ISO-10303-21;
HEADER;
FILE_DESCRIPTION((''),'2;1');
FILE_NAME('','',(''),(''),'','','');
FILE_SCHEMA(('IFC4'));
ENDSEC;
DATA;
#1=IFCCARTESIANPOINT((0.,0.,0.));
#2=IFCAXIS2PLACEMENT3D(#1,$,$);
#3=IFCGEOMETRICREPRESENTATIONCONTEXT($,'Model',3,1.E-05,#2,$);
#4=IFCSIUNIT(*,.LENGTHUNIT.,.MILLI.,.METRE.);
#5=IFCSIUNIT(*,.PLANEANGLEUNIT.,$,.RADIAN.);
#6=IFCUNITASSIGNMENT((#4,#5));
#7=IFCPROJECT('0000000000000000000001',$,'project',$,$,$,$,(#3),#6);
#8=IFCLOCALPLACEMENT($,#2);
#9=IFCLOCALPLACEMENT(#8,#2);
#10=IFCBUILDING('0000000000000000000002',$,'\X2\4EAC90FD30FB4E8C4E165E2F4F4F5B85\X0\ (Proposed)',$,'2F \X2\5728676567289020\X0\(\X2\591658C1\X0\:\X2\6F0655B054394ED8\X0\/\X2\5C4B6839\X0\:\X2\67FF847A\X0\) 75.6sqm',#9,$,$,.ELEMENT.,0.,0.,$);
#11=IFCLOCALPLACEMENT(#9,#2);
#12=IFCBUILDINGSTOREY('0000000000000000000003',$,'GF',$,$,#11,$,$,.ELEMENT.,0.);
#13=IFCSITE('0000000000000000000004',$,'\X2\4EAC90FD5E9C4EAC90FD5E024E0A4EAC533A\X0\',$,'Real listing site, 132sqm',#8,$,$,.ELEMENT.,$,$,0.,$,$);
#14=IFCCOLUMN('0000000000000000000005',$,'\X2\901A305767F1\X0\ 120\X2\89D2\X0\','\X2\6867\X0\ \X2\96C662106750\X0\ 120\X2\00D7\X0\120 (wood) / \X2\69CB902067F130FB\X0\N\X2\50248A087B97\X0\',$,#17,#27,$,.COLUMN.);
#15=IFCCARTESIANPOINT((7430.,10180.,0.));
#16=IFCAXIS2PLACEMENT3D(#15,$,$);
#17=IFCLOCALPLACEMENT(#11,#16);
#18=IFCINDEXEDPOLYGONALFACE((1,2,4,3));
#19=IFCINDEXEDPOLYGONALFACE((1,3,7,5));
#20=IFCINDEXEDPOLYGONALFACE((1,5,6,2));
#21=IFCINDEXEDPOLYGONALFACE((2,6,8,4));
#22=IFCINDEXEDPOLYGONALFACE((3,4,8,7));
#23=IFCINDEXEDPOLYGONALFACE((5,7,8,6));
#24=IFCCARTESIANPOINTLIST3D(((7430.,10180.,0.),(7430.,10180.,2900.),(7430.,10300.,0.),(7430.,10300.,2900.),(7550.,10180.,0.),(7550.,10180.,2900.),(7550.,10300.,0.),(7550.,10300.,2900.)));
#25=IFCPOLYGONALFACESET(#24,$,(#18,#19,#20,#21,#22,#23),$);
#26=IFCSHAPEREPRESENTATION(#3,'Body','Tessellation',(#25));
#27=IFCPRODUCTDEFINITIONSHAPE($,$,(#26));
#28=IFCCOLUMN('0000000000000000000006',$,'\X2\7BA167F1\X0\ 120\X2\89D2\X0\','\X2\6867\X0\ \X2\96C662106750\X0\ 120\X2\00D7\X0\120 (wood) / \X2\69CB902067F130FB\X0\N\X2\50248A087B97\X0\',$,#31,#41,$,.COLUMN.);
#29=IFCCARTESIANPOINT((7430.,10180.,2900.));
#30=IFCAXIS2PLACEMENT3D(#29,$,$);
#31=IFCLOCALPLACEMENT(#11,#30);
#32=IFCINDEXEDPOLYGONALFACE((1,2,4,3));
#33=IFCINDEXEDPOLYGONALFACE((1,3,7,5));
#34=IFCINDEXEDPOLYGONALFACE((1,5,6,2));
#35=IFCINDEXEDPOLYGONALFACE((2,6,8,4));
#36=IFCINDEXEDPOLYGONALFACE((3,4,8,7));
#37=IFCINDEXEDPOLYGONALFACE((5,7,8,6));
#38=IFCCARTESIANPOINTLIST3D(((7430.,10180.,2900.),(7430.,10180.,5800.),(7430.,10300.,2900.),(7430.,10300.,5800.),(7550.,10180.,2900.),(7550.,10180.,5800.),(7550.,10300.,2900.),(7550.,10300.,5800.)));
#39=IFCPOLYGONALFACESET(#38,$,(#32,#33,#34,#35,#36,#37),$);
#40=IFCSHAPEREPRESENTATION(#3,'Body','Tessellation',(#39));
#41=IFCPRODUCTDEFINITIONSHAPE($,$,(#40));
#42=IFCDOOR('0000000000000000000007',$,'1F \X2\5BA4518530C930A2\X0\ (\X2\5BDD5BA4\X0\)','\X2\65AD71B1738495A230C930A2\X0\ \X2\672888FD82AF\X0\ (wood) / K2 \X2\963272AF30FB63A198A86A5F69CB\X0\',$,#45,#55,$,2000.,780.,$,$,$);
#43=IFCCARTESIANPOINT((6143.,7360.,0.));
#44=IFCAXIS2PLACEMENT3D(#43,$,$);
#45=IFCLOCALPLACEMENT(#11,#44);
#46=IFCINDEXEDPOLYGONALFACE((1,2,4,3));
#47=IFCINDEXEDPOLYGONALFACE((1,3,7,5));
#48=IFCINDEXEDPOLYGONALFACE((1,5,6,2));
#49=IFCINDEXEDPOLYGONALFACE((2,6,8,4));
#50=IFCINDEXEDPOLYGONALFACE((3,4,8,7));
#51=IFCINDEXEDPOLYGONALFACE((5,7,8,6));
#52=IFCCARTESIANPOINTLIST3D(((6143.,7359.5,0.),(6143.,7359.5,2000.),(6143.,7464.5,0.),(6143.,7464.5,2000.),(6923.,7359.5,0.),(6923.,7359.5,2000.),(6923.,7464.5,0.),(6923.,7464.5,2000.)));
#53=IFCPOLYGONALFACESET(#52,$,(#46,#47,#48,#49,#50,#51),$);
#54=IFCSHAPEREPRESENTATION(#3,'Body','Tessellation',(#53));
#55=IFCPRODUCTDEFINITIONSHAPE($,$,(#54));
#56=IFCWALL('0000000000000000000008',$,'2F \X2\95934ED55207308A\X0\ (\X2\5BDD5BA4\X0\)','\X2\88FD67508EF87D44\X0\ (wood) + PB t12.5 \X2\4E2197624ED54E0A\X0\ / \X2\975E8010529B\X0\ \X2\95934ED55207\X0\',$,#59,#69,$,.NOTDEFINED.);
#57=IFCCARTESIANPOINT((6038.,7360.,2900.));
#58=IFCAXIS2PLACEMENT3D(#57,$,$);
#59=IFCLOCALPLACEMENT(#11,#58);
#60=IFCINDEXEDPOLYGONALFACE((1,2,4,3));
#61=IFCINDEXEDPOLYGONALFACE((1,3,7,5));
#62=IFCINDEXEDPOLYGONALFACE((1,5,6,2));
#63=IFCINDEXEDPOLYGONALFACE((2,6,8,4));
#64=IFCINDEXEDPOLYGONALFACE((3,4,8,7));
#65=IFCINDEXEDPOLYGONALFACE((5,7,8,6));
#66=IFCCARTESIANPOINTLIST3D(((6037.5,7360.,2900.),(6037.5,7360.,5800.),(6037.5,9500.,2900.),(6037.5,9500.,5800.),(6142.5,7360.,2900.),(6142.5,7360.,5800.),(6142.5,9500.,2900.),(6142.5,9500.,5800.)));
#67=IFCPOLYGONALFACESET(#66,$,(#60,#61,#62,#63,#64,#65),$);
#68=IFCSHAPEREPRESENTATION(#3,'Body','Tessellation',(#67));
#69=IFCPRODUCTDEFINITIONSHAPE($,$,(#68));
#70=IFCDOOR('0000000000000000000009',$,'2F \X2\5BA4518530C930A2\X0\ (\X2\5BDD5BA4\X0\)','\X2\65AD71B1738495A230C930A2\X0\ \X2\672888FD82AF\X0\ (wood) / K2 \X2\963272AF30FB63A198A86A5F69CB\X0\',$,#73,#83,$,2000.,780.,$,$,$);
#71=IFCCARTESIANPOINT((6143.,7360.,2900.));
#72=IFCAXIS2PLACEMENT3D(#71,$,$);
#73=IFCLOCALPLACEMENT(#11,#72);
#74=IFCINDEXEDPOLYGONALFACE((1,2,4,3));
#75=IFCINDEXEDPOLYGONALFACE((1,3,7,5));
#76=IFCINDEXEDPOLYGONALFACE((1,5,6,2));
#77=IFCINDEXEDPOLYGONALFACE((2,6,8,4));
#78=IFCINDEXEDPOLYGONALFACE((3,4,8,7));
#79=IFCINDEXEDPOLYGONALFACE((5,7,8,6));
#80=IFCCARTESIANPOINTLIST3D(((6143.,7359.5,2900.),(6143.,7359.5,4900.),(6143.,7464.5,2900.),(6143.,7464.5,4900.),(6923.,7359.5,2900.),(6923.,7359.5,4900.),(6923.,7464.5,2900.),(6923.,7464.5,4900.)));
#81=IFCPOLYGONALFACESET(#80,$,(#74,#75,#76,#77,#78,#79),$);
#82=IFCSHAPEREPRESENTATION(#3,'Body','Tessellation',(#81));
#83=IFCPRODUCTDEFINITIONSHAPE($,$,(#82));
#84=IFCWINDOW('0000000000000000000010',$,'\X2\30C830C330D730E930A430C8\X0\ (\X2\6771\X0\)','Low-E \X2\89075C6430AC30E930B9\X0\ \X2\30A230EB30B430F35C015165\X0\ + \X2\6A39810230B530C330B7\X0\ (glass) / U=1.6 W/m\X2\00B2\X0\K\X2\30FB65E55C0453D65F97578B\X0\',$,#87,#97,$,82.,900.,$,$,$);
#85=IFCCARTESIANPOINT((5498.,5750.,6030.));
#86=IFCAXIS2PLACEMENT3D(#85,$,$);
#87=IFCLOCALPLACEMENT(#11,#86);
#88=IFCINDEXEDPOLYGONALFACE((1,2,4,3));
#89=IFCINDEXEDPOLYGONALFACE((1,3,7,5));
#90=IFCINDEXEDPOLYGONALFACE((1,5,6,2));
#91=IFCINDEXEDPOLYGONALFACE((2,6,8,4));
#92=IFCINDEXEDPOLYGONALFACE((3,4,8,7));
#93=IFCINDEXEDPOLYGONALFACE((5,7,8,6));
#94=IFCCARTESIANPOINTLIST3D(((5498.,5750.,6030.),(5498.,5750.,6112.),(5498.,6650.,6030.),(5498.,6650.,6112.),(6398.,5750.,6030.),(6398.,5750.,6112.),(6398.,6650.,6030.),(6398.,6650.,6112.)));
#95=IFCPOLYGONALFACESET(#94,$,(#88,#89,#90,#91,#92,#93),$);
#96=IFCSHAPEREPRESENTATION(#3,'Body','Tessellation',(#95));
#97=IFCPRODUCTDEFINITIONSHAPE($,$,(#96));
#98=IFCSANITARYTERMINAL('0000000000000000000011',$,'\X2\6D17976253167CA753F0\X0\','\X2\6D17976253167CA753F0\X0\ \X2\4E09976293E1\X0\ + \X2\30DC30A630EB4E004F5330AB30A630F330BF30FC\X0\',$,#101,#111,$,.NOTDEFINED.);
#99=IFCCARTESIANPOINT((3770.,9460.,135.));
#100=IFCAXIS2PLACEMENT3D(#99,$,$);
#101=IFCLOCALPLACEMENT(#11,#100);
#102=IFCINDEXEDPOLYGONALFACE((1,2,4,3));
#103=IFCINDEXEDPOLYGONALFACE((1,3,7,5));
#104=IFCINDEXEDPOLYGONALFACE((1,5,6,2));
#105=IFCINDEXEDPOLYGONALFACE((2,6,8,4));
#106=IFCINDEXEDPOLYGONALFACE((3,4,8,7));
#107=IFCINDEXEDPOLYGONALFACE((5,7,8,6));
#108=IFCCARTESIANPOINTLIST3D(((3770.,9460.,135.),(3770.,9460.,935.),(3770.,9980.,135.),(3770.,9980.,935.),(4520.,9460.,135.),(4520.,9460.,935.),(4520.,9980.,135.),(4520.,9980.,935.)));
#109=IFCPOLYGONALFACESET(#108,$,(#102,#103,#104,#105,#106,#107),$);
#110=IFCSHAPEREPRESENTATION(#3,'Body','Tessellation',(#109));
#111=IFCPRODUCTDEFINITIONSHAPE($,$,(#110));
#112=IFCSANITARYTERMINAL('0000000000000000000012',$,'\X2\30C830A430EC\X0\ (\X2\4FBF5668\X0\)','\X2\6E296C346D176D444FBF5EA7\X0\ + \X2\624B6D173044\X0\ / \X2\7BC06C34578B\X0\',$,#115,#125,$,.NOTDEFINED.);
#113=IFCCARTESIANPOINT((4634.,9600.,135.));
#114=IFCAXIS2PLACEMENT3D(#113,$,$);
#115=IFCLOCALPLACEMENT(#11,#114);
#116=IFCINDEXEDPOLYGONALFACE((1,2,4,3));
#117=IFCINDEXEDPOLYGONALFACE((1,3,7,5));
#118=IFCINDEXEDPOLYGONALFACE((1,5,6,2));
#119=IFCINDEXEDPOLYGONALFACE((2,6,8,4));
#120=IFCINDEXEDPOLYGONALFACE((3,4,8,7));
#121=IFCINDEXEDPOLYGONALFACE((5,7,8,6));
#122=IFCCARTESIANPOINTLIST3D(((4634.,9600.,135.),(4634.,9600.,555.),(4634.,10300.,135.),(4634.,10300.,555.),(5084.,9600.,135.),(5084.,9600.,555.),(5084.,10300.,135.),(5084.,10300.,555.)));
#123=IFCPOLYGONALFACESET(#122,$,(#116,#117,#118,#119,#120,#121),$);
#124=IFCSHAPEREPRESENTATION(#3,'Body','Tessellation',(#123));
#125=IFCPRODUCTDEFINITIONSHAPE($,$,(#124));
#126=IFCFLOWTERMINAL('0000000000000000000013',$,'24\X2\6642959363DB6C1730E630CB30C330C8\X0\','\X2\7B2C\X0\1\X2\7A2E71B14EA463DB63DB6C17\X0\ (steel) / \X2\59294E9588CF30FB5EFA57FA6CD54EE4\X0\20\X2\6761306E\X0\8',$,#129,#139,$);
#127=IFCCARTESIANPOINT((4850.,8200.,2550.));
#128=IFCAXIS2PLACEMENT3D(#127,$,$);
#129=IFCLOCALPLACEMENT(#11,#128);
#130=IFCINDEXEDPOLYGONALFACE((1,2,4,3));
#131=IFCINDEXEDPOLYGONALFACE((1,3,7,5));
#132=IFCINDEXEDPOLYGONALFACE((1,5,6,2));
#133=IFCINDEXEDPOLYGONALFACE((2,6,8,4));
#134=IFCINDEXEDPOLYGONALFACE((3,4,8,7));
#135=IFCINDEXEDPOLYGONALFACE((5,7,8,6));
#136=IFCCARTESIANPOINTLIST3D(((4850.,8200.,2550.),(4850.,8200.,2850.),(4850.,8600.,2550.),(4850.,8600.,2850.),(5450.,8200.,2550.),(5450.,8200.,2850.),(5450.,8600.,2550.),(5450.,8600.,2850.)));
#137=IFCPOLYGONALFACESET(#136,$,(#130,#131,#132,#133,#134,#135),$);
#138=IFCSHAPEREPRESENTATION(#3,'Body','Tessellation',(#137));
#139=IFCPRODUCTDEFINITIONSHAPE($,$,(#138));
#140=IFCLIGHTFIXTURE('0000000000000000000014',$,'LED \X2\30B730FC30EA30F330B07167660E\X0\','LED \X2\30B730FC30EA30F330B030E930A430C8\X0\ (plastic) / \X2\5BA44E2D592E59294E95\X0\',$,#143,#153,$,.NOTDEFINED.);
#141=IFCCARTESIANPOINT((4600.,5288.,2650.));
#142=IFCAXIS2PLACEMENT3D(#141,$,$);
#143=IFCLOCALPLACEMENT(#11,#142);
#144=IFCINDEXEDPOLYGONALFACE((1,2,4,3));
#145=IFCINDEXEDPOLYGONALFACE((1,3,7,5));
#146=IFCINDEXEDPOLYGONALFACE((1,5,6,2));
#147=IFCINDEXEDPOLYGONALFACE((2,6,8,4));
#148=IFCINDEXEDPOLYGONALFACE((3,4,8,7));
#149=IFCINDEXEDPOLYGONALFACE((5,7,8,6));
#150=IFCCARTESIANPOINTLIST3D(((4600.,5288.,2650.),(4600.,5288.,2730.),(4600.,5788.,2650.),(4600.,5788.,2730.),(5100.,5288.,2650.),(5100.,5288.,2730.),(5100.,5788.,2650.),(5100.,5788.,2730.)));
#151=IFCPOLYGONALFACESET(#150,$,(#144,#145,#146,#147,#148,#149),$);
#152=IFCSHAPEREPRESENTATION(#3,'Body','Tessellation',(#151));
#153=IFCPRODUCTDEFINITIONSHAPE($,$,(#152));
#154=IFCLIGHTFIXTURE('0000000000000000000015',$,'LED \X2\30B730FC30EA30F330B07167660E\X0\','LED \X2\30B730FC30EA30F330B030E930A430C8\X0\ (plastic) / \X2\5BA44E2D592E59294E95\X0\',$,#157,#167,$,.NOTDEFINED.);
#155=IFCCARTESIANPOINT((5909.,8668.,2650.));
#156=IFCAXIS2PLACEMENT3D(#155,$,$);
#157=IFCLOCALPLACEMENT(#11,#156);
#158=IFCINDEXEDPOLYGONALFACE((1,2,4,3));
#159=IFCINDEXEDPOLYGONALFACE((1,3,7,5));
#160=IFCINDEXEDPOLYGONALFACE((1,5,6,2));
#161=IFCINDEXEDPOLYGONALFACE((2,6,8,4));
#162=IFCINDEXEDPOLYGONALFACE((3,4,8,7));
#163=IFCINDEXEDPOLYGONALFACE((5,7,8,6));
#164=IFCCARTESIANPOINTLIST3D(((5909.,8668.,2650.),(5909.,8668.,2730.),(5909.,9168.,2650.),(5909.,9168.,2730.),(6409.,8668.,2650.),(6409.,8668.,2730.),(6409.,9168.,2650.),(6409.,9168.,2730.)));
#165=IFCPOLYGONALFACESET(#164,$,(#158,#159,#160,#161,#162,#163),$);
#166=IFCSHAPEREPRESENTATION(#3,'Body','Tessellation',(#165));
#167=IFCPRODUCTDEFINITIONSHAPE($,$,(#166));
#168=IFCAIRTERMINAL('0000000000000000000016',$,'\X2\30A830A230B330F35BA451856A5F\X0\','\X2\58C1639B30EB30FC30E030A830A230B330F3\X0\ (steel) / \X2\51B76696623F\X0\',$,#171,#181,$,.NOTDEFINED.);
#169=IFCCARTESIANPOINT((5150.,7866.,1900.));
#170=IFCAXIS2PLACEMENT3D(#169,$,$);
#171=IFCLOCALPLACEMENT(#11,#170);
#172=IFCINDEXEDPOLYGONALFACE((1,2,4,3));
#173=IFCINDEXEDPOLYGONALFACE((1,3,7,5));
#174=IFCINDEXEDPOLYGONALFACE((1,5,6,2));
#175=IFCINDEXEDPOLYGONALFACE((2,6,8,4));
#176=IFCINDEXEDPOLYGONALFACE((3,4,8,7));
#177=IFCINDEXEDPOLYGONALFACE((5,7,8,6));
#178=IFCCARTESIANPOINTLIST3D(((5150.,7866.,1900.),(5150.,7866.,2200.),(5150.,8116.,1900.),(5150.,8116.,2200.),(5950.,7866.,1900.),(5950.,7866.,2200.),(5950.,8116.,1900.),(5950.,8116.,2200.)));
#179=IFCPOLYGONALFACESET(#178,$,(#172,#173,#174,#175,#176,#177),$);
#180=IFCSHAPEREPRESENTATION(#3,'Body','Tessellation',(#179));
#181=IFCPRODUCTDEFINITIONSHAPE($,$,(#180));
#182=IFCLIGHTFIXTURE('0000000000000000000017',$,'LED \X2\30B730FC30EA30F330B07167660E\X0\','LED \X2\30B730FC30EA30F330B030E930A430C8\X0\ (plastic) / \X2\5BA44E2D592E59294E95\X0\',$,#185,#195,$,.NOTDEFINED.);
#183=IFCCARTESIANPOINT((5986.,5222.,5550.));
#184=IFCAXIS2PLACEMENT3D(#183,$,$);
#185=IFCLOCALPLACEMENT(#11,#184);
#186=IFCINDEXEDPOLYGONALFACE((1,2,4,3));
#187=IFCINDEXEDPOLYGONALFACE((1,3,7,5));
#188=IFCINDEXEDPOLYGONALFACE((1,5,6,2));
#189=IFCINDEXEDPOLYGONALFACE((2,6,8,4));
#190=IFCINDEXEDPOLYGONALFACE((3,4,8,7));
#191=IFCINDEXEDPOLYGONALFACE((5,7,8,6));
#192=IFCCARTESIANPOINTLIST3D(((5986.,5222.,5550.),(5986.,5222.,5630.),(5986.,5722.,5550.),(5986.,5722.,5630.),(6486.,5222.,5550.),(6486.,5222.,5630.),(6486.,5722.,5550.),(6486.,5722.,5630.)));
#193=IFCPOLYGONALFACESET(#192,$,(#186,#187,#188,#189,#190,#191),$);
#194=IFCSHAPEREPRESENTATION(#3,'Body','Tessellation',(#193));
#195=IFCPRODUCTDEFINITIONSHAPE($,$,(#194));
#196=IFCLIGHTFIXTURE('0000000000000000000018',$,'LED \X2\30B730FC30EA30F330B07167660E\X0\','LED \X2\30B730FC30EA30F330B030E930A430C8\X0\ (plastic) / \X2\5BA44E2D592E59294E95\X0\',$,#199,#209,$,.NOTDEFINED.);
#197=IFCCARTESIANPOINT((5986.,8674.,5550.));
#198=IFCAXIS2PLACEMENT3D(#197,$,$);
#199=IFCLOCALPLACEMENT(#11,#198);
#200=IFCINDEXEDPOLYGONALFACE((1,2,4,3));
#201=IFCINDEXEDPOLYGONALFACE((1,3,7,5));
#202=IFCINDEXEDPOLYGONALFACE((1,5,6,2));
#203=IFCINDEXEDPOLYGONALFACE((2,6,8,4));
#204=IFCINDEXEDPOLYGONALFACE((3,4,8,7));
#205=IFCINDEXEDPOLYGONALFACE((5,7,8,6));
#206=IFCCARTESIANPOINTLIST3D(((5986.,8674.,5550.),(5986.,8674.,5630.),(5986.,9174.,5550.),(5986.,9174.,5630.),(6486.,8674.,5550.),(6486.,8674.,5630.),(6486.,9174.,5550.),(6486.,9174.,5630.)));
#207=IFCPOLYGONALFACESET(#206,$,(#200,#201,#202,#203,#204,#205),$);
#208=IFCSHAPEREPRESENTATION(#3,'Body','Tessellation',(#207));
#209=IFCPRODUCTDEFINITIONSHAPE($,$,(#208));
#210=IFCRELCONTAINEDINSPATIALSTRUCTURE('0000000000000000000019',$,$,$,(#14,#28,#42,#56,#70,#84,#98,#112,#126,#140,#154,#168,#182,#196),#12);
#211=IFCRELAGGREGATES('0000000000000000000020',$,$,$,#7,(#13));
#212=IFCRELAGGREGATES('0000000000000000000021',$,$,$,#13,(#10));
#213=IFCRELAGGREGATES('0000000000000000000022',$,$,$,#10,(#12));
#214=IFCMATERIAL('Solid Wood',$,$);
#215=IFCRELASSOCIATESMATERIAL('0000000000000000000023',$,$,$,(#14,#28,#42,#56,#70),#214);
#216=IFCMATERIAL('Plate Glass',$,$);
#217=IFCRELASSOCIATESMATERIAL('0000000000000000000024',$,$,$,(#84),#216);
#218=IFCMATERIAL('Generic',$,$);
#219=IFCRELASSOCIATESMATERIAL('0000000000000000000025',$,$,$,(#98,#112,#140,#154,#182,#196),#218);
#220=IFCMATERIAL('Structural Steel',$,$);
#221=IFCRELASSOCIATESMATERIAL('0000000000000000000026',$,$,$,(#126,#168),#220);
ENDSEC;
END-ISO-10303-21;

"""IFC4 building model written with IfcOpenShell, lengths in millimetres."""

from ifc_helpers import new_model, si_unit, frame, frame_2d, origin, place, context, project, spatial, rectangle, extrude, material, element, save


model = new_model("IFC4")

# Units and contexts
model_context = context("Model", 3, precision=1e-05, world=origin())
ifc_project = project(units=[si_unit("LENGTHUNIT", "METRE", prefix="MILLI"), si_unit("PLANEANGLEUNIT", "RADIAN")], contexts=[model_context])

# Site, building, storey
site_placement = place(None, origin())
site = spatial("IfcSite", under=ifc_project, at=site_placement, Name="京都府京都市上京区", ObjectType="Real listing site, 132sqm", CompositionType="ELEMENT", RefElevation=0.0)
building_placement = place(site_placement, origin())
building = spatial("IfcBuilding", under=site, at=building_placement, Name="京都・二世帯住宅 (Proposed)", ObjectType="2F 在来木造(外壁:漆喰吹付/屋根:柿葺) 75.6sqm", CompositionType="ELEMENT", ElevationOfRefHeight=0.0, ElevationOfTerrain=0.0)
storey_placement = place(building_placement, origin())
storey = spatial("IfcBuildingStorey", under=building, at=storey_placement, Name="GF", CompositionType="ELEMENT", Elevation=0.0)

# Columns
ifc_material_1 = material(Name="Solid Wood")
column_1_placement = place(storey_placement, frame((7430.0, 10180.0, 0.0)))
element("IfcColumn", 1, at=column_1_placement, inside=storey, material=ifc_material_1, Name="通し柱 120角", Description="桧 集成材 120×120 (wood) / 構造柱・N値計算", PredefinedType="COLUMN", context=model_context, shape_type="SweptSolid", body=[
    extrude(rectangle(XDim=120.0, YDim=120.0, at=frame_2d((60.0, 60.0))), frame((7430.0, 10180.0, 0.0)), (0.0, 0.0, 1.0), 2900.0),
])
column_2_placement = place(storey_placement, frame((7430.0, 10180.0, 2900.0)))
element("IfcColumn", 2, at=column_2_placement, inside=storey, material=ifc_material_1, Name="管柱 120角", Description="桧 集成材 120×120 (wood) / 構造柱・N値計算", PredefinedType="COLUMN", context=model_context, shape_type="SweptSolid", body=[
    extrude(rectangle(XDim=120.0, YDim=120.0, at=frame_2d((60.0, 60.0))), frame((7430.0, 10180.0, 2900.0)), (0.0, 0.0, 1.0), 2900.0),
])

# Door
door_1_placement = place(storey_placement, frame((6143.0, 7360.0, 0.0)))
element("IfcDoor", 3, at=door_1_placement, inside=storey, material=ifc_material_1, Name="1F 室内ドア (寝室)", Description="断熱玄関ドア 木製芯 (wood) / K2 防犯・採風機構", OverallHeight=2000.0, OverallWidth=780.0, context=model_context, shape_type="SweptSolid", body=[
    extrude(rectangle(XDim=780.0, YDim=105.0, at=frame_2d((390.0, 52.0))), frame((6143.0, 7360.0, 0.0)), (0.0, 0.0, 1.0), 2000.0),
])

# Wall
wall_1_placement = place(storey_placement, frame((6038.0, 7360.0, 2900.0)))
element("IfcWall", 4, at=wall_1_placement, inside=storey, material=ifc_material_1, Name="2F 間仕切り (寝室)", Description="製材軸組 (wood) + PB t12.5 両面仕上 / 非耐力 間仕切", PredefinedType="NOTDEFINED", context=model_context, shape_type="SweptSolid", body=[
    extrude(rectangle(XDim=105.0, YDim=2140.0, at=frame_2d((52.0, 1070.0))), frame((6038.0, 7360.0, 2900.0)), (0.0, 0.0, 1.0), 2900.0),
])

# Door
door_2_placement = place(storey_placement, frame((6143.0, 7360.0, 2900.0)))
element("IfcDoor", 5, at=door_2_placement, inside=storey, material=ifc_material_1, Name="2F 室内ドア (寝室)", Description="断熱玄関ドア 木製芯 (wood) / K2 防犯・採風機構", OverallHeight=2000.0, OverallWidth=780.0, context=model_context, shape_type="SweptSolid", body=[
    extrude(rectangle(XDim=780.0, YDim=105.0, at=frame_2d((390.0, 52.0))), frame((6143.0, 7360.0, 2900.0)), (0.0, 0.0, 1.0), 2000.0),
])

# Window
ifc_material_2 = material(Name="Plate Glass")
window_placement = place(storey_placement, frame((5498.0, 5750.0, 6030.0)))
element("IfcWindow", 6, at=window_placement, inside=storey, material=ifc_material_2, Name="トップライト (東)", Description="Low-E 複層ガラス アルゴン封入 + 樹脂サッシ (glass) / U=1.6 W/m²K・日射取得型", OverallHeight=82.0, OverallWidth=900.0, context=model_context, shape_type="SweptSolid", body=[
    extrude(rectangle(XDim=900.0, YDim=900.0, at=frame_2d((450.0, 450.0))), frame((5498.0, 5750.0, 6030.0)), (0.0, 0.0, 1.0), 82.0),
])

# Sanitary terminals
ifc_material_3 = material(Name="Generic")
sanitary_terminal_1_placement = place(storey_placement, frame((3770.0, 9460.0, 135.0)))
element("IfcSanitaryTerminal", 7, at=sanitary_terminal_1_placement, inside=storey, material=ifc_material_3, Name="洗面化粧台", Description="洗面化粧台 三面鏡 + ボウル一体カウンター", PredefinedType="NOTDEFINED", context=model_context, shape_type="SweptSolid", body=[
    extrude(rectangle(XDim=750.0, YDim=520.0, at=frame_2d((375.0, 260.0))), frame((3770.0, 9460.0, 135.0)), (0.0, 0.0, 1.0), 800.0),
])
sanitary_terminal_2_placement = place(storey_placement, frame((4634.0, 9600.0, 135.0)))
element("IfcSanitaryTerminal", 8, at=sanitary_terminal_2_placement, inside=storey, material=ifc_material_3, Name="トイレ (便器)", Description="温水洗浄便座 + 手洗い / 節水型", PredefinedType="NOTDEFINED", context=model_context, shape_type="SweptSolid", body=[
    extrude(rectangle(XDim=450.0, YDim=700.0, at=frame_2d((225.0, 350.0))), frame((4634.0, 9600.0, 135.0)), (0.0, 0.0, 1.0), 420.0),
])

# Flow terminal
ifc_material_4 = material(Name="Structural Steel")
flow_terminal_placement = place(storey_placement, frame((4850.0, 8200.0, 2550.0)))
element("IfcFlowTerminal", 9, at=flow_terminal_placement, inside=storey, material=ifc_material_4, Name="24時間換気ユニット", Description="第1種熱交換換気 (steel) / 天井裏・建基法令20条の8", context=model_context, shape_type="SweptSolid", body=[
    extrude(rectangle(XDim=600.0, YDim=400.0, at=frame_2d((300.0, 200.0))), frame((4850.0, 8200.0, 2550.0)), (0.0, 0.0, 1.0), 300.0),
])

# Light fixtures
light_fixture_1_placement = place(storey_placement, frame((4600.0, 5288.0, 2650.0)))
element("IfcLightFixture", 10, at=light_fixture_1_placement, inside=storey, material=ifc_material_3, Name="LED シーリング照明", Description="LED シーリングライト (plastic) / 室中央天井", PredefinedType="NOTDEFINED", context=model_context, shape_type="SweptSolid", body=[
    extrude(rectangle(XDim=500.0, YDim=500.0, at=frame_2d((250.0, 250.0))), frame((4600.0, 5288.0, 2650.0)), (0.0, 0.0, 1.0), 80.0),
])
light_fixture_2_placement = place(storey_placement, frame((5909.0, 8668.0, 2650.0)))
element("IfcLightFixture", 11, at=light_fixture_2_placement, inside=storey, material=ifc_material_3, Name="LED シーリング照明", Description="LED シーリングライト (plastic) / 室中央天井", PredefinedType="NOTDEFINED", context=model_context, shape_type="SweptSolid", body=[
    extrude(rectangle(XDim=500.0, YDim=500.0, at=frame_2d((250.0, 250.0))), frame((5909.0, 8668.0, 2650.0)), (0.0, 0.0, 1.0), 80.0),
])

# Air terminal
air_terminal_placement = place(storey_placement, frame((5150.0, 7866.0, 1900.0)))
element("IfcAirTerminal", 12, at=air_terminal_placement, inside=storey, material=ifc_material_4, Name="エアコン室内機", Description="壁掛ルームエアコン (steel) / 冷暖房", PredefinedType="NOTDEFINED", context=model_context, shape_type="SweptSolid", body=[
    extrude(rectangle(XDim=800.0, YDim=250.0, at=frame_2d((400.0, 125.0))), frame((5150.0, 7866.0, 1900.0)), (0.0, 0.0, 1.0), 300.0),
])

# Light fixtures
light_fixture_3_placement = place(storey_placement, frame((5986.0, 5222.0, 5550.0)))
element("IfcLightFixture", 13, at=light_fixture_3_placement, inside=storey, material=ifc_material_3, Name="LED シーリング照明", Description="LED シーリングライト (plastic) / 室中央天井", PredefinedType="NOTDEFINED", context=model_context, shape_type="SweptSolid", body=[
    extrude(rectangle(XDim=500.0, YDim=500.0, at=frame_2d((250.0, 250.0))), frame((5986.0, 5222.0, 5550.0)), (0.0, 0.0, 1.0), 80.0),
])
light_fixture_4_placement = place(storey_placement, frame((5986.0, 8674.0, 5550.0)))
element("IfcLightFixture", 14, at=light_fixture_4_placement, inside=storey, material=ifc_material_3, Name="LED シーリング照明", Description="LED シーリングライト (plastic) / 室中央天井", PredefinedType="NOTDEFINED", context=model_context, shape_type="SweptSolid", body=[
    extrude(rectangle(XDim=500.0, YDim=500.0, at=frame_2d((250.0, 250.0))), frame((5986.0, 8674.0, 5550.0)), (0.0, 0.0, 1.0), 80.0),
])

save(model, "model.ifc")
